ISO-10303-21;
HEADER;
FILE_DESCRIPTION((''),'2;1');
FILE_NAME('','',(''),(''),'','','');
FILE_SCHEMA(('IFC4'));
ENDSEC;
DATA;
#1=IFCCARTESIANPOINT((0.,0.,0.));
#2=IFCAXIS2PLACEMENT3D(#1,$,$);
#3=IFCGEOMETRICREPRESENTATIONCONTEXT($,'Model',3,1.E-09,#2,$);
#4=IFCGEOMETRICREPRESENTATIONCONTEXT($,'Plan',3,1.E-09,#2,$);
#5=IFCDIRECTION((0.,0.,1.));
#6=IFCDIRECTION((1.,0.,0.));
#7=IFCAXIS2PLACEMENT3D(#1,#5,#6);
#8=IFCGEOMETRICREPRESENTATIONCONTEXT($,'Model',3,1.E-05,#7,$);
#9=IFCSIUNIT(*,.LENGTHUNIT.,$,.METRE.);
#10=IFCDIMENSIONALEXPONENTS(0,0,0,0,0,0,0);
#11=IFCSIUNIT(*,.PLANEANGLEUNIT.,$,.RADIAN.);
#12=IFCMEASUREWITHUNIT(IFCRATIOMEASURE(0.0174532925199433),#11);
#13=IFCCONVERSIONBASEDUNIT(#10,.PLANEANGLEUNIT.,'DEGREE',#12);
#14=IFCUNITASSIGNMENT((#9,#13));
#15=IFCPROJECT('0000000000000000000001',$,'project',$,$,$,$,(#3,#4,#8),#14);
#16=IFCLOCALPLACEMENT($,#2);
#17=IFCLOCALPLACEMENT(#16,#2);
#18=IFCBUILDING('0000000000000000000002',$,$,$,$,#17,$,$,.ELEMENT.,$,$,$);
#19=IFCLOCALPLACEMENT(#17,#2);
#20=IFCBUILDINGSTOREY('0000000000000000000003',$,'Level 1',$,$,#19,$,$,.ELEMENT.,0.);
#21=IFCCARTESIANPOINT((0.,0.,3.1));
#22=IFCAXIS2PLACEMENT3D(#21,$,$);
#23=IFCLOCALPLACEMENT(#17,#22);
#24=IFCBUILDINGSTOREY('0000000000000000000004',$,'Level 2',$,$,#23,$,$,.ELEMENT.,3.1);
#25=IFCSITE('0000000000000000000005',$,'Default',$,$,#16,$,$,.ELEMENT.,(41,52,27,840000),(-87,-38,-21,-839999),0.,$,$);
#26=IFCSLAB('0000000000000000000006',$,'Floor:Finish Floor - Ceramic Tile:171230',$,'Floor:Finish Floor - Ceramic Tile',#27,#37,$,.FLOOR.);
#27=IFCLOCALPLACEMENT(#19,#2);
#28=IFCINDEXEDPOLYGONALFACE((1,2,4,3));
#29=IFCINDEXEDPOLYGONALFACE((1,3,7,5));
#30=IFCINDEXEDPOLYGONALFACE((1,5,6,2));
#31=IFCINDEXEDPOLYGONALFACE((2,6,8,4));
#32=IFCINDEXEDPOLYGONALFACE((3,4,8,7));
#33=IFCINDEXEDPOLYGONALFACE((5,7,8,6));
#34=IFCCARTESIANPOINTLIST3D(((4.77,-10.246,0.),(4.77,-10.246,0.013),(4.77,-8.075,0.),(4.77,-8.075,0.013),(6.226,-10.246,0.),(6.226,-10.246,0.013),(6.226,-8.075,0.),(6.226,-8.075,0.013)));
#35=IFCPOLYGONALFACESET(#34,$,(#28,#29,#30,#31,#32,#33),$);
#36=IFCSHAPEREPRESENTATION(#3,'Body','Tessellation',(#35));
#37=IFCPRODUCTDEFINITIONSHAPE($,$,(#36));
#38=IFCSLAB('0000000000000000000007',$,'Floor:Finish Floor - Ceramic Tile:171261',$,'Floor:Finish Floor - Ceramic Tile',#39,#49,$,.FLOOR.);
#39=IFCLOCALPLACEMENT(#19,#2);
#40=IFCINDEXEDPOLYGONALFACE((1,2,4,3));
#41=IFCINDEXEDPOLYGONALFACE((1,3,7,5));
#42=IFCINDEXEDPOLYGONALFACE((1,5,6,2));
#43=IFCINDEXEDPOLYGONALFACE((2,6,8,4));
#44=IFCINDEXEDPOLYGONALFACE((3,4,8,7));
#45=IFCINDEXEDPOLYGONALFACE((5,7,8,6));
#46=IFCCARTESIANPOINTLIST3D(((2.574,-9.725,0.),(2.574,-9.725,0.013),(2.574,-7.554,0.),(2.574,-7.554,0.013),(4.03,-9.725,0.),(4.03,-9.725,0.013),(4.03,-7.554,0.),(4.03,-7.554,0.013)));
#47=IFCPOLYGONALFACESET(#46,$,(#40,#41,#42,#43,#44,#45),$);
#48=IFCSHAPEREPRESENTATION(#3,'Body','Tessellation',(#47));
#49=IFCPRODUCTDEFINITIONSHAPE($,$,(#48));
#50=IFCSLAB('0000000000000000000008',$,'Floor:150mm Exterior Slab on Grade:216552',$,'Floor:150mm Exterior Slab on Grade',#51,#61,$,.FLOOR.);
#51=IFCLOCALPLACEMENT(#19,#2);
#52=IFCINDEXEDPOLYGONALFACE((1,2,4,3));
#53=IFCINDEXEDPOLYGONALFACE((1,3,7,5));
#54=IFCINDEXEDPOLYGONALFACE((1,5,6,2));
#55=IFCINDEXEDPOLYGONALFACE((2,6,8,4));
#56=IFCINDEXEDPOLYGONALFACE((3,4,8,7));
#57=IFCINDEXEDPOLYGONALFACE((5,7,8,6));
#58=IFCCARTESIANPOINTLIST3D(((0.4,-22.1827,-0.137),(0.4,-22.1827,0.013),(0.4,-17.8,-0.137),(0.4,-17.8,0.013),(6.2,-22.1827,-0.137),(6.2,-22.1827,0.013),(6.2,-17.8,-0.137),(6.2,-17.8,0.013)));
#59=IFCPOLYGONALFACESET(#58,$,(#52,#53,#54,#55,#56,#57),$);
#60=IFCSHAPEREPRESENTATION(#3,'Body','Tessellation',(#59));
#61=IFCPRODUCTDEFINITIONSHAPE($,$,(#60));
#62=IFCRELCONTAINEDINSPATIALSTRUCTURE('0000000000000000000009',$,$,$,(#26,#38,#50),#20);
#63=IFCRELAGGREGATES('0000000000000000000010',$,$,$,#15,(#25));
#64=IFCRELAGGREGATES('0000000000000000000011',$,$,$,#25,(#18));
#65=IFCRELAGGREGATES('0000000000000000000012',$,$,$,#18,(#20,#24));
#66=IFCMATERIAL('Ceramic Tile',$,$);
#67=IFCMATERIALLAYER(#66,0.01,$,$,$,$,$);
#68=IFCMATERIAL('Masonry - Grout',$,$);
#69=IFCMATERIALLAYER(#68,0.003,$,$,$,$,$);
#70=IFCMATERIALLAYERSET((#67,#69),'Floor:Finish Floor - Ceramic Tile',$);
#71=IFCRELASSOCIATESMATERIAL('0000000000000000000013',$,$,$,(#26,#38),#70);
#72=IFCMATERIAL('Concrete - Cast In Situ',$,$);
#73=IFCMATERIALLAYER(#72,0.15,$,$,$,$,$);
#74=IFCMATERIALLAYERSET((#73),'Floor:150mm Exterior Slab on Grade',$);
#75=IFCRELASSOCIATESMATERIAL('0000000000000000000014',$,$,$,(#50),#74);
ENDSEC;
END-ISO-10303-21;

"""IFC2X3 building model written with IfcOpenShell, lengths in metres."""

from ifc_helpers import new_model, entity, si_unit, converted_unit, frame, frame_2d, origin, origin_with_axes, origin_2d_with_axis, place, context, project, spatial, rectangle, extrude, material, layer, layer_set, layer_usage, element, save


model = new_model("IFC2X3")

# Units and contexts
model_context_1 = context("Model", 3, precision=1e-09, world=origin())
plan_context = context("Plan", 3, precision=1e-09, world=origin())
model_context_2 = context("Model", 3, precision=1e-05, world=origin_with_axes())
ifc_project = project(units=[si_unit("LENGTHUNIT", "METRE"), converted_unit("PLANEANGLEUNIT", "DEGREE", entity("IfcRatioMeasure", 0.0174532925199433), si_unit("PLANEANGLEUNIT", "RADIAN"), dimensions=[0, 0, 0, 0, 0, 0, 0])], contexts=[model_context_1, plan_context, model_context_2])

# Site, building, storey
site_placement = place(None, origin())
site = spatial("IfcSite", under=ifc_project, at=site_placement, Name="Default", CompositionType="ELEMENT", RefLatitude=(41, 52, 27, 840000), RefLongitude=(-87, -38, -21, -839999), RefElevation=0.0)
building_placement = place(site_placement, origin())
building = spatial("IfcBuilding", under=site, at=building_placement, CompositionType="ELEMENT")
storey_1_placement = place(building_placement, origin())
storey_1 = spatial("IfcBuildingStorey", under=building, at=storey_1_placement, Name="Level 1", CompositionType="ELEMENT", Elevation=0.0)

# Slabs
ifc_material_1 = material(Name="Ceramic Tile")
ifc_layer_1 = layer(ifc_material_1, 0.01)
ifc_material_2 = material(Name="Masonry - Grout")
ifc_layer_2 = layer(ifc_material_2, 0.003)
ifc_layer_set_1 = layer_set([ifc_layer_1, ifc_layer_2], Name="Floor:Finish Floor - Ceramic Tile")
ifc_layer_usage_1 = layer_usage(ifc_layer_set_1, "AXIS3", "POSITIVE", 0.0)
slab_1_placement = place(storey_1_placement, frame((4.77, -10.246, 0.0)))
element("IfcSlab", 1, at=slab_1_placement, inside=storey_1, material=ifc_layer_usage_1, Name="Floor:Finish Floor - Ceramic Tile:171230", ObjectType="Floor:Finish Floor - Ceramic Tile", PredefinedType="FLOOR", context=model_context_1, shape_type="SweptSolid", body=[
    extrude(rectangle(XDim=1.456, YDim=2.171, at=frame_2d((0.0, 0.0), x_axis=(-1.0, 0.0))), frame((0.728, 1.0855, 0.013), z_axis=(0.0, 0.0, -1.0), x_axis=(-1.0, 0.0, 0.0)), (0.0, 0.0, 1.0), 0.013),
])
ifc_layer_usage_2 = layer_usage(ifc_layer_set_1, "AXIS3", "POSITIVE", 0.0)
slab_2_placement = place(storey_1_placement, frame((2.574, -9.725, 0.0)))
element("IfcSlab", 2, at=slab_2_placement, inside=storey_1, material=ifc_layer_usage_2, Name="Floor:Finish Floor - Ceramic Tile:171261", ObjectType="Floor:Finish Floor - Ceramic Tile", PredefinedType="FLOOR", context=model_context_1, shape_type="SweptSolid", body=[
    extrude(rectangle(XDim=2.171, YDim=1.456, at=frame_2d((0.0, 0.0), x_axis=(0.0, -1.0))), frame((0.728, 1.0855, 0.013), z_axis=(0.0, 0.0, -1.0), x_axis=(-1.0, 0.0, 0.0)), (0.0, 0.0, 1.0), 0.013),
])
ifc_material_3 = material(Name="Concrete - Cast In Situ")
ifc_layer_3 = layer(ifc_material_3, 0.15)
ifc_layer_set_2 = layer_set([ifc_layer_3], Name="Floor:150mm Exterior Slab on Grade")
ifc_layer_usage_3 = layer_usage(ifc_layer_set_2, "AXIS3", "POSITIVE", 0.0)
slab_3_placement = place(storey_1_placement, frame((0.4, -22.1827, -0.137)))
element("IfcSlab", 3, at=slab_3_placement, inside=storey_1, material=ifc_layer_usage_3, Name="Floor:150mm Exterior Slab on Grade:216552", ObjectType="Floor:150mm Exterior Slab on Grade", PredefinedType="FLOOR", context=model_context_1, shape_type="SweptSolid", body=[
    extrude(rectangle(XDim=5.8, YDim=4.3827, at=origin_2d_with_axis()), frame((2.9, 2.1914, 0.15), z_axis=(0.0, 0.0, -1.0), x_axis=(-1.0, 0.0, 0.0)), (0.0, 0.0, 1.0), 0.15),
])

# Shared definitions
storey_2_placement = place(building_placement, frame((0.0, 0.0, 3.1)))
storey_2 = spatial("IfcBuildingStorey", under=building, at=storey_2_placement, Name="Level 2", CompositionType="ELEMENT", Elevation=3.1)

save(model, "model.ifc")
